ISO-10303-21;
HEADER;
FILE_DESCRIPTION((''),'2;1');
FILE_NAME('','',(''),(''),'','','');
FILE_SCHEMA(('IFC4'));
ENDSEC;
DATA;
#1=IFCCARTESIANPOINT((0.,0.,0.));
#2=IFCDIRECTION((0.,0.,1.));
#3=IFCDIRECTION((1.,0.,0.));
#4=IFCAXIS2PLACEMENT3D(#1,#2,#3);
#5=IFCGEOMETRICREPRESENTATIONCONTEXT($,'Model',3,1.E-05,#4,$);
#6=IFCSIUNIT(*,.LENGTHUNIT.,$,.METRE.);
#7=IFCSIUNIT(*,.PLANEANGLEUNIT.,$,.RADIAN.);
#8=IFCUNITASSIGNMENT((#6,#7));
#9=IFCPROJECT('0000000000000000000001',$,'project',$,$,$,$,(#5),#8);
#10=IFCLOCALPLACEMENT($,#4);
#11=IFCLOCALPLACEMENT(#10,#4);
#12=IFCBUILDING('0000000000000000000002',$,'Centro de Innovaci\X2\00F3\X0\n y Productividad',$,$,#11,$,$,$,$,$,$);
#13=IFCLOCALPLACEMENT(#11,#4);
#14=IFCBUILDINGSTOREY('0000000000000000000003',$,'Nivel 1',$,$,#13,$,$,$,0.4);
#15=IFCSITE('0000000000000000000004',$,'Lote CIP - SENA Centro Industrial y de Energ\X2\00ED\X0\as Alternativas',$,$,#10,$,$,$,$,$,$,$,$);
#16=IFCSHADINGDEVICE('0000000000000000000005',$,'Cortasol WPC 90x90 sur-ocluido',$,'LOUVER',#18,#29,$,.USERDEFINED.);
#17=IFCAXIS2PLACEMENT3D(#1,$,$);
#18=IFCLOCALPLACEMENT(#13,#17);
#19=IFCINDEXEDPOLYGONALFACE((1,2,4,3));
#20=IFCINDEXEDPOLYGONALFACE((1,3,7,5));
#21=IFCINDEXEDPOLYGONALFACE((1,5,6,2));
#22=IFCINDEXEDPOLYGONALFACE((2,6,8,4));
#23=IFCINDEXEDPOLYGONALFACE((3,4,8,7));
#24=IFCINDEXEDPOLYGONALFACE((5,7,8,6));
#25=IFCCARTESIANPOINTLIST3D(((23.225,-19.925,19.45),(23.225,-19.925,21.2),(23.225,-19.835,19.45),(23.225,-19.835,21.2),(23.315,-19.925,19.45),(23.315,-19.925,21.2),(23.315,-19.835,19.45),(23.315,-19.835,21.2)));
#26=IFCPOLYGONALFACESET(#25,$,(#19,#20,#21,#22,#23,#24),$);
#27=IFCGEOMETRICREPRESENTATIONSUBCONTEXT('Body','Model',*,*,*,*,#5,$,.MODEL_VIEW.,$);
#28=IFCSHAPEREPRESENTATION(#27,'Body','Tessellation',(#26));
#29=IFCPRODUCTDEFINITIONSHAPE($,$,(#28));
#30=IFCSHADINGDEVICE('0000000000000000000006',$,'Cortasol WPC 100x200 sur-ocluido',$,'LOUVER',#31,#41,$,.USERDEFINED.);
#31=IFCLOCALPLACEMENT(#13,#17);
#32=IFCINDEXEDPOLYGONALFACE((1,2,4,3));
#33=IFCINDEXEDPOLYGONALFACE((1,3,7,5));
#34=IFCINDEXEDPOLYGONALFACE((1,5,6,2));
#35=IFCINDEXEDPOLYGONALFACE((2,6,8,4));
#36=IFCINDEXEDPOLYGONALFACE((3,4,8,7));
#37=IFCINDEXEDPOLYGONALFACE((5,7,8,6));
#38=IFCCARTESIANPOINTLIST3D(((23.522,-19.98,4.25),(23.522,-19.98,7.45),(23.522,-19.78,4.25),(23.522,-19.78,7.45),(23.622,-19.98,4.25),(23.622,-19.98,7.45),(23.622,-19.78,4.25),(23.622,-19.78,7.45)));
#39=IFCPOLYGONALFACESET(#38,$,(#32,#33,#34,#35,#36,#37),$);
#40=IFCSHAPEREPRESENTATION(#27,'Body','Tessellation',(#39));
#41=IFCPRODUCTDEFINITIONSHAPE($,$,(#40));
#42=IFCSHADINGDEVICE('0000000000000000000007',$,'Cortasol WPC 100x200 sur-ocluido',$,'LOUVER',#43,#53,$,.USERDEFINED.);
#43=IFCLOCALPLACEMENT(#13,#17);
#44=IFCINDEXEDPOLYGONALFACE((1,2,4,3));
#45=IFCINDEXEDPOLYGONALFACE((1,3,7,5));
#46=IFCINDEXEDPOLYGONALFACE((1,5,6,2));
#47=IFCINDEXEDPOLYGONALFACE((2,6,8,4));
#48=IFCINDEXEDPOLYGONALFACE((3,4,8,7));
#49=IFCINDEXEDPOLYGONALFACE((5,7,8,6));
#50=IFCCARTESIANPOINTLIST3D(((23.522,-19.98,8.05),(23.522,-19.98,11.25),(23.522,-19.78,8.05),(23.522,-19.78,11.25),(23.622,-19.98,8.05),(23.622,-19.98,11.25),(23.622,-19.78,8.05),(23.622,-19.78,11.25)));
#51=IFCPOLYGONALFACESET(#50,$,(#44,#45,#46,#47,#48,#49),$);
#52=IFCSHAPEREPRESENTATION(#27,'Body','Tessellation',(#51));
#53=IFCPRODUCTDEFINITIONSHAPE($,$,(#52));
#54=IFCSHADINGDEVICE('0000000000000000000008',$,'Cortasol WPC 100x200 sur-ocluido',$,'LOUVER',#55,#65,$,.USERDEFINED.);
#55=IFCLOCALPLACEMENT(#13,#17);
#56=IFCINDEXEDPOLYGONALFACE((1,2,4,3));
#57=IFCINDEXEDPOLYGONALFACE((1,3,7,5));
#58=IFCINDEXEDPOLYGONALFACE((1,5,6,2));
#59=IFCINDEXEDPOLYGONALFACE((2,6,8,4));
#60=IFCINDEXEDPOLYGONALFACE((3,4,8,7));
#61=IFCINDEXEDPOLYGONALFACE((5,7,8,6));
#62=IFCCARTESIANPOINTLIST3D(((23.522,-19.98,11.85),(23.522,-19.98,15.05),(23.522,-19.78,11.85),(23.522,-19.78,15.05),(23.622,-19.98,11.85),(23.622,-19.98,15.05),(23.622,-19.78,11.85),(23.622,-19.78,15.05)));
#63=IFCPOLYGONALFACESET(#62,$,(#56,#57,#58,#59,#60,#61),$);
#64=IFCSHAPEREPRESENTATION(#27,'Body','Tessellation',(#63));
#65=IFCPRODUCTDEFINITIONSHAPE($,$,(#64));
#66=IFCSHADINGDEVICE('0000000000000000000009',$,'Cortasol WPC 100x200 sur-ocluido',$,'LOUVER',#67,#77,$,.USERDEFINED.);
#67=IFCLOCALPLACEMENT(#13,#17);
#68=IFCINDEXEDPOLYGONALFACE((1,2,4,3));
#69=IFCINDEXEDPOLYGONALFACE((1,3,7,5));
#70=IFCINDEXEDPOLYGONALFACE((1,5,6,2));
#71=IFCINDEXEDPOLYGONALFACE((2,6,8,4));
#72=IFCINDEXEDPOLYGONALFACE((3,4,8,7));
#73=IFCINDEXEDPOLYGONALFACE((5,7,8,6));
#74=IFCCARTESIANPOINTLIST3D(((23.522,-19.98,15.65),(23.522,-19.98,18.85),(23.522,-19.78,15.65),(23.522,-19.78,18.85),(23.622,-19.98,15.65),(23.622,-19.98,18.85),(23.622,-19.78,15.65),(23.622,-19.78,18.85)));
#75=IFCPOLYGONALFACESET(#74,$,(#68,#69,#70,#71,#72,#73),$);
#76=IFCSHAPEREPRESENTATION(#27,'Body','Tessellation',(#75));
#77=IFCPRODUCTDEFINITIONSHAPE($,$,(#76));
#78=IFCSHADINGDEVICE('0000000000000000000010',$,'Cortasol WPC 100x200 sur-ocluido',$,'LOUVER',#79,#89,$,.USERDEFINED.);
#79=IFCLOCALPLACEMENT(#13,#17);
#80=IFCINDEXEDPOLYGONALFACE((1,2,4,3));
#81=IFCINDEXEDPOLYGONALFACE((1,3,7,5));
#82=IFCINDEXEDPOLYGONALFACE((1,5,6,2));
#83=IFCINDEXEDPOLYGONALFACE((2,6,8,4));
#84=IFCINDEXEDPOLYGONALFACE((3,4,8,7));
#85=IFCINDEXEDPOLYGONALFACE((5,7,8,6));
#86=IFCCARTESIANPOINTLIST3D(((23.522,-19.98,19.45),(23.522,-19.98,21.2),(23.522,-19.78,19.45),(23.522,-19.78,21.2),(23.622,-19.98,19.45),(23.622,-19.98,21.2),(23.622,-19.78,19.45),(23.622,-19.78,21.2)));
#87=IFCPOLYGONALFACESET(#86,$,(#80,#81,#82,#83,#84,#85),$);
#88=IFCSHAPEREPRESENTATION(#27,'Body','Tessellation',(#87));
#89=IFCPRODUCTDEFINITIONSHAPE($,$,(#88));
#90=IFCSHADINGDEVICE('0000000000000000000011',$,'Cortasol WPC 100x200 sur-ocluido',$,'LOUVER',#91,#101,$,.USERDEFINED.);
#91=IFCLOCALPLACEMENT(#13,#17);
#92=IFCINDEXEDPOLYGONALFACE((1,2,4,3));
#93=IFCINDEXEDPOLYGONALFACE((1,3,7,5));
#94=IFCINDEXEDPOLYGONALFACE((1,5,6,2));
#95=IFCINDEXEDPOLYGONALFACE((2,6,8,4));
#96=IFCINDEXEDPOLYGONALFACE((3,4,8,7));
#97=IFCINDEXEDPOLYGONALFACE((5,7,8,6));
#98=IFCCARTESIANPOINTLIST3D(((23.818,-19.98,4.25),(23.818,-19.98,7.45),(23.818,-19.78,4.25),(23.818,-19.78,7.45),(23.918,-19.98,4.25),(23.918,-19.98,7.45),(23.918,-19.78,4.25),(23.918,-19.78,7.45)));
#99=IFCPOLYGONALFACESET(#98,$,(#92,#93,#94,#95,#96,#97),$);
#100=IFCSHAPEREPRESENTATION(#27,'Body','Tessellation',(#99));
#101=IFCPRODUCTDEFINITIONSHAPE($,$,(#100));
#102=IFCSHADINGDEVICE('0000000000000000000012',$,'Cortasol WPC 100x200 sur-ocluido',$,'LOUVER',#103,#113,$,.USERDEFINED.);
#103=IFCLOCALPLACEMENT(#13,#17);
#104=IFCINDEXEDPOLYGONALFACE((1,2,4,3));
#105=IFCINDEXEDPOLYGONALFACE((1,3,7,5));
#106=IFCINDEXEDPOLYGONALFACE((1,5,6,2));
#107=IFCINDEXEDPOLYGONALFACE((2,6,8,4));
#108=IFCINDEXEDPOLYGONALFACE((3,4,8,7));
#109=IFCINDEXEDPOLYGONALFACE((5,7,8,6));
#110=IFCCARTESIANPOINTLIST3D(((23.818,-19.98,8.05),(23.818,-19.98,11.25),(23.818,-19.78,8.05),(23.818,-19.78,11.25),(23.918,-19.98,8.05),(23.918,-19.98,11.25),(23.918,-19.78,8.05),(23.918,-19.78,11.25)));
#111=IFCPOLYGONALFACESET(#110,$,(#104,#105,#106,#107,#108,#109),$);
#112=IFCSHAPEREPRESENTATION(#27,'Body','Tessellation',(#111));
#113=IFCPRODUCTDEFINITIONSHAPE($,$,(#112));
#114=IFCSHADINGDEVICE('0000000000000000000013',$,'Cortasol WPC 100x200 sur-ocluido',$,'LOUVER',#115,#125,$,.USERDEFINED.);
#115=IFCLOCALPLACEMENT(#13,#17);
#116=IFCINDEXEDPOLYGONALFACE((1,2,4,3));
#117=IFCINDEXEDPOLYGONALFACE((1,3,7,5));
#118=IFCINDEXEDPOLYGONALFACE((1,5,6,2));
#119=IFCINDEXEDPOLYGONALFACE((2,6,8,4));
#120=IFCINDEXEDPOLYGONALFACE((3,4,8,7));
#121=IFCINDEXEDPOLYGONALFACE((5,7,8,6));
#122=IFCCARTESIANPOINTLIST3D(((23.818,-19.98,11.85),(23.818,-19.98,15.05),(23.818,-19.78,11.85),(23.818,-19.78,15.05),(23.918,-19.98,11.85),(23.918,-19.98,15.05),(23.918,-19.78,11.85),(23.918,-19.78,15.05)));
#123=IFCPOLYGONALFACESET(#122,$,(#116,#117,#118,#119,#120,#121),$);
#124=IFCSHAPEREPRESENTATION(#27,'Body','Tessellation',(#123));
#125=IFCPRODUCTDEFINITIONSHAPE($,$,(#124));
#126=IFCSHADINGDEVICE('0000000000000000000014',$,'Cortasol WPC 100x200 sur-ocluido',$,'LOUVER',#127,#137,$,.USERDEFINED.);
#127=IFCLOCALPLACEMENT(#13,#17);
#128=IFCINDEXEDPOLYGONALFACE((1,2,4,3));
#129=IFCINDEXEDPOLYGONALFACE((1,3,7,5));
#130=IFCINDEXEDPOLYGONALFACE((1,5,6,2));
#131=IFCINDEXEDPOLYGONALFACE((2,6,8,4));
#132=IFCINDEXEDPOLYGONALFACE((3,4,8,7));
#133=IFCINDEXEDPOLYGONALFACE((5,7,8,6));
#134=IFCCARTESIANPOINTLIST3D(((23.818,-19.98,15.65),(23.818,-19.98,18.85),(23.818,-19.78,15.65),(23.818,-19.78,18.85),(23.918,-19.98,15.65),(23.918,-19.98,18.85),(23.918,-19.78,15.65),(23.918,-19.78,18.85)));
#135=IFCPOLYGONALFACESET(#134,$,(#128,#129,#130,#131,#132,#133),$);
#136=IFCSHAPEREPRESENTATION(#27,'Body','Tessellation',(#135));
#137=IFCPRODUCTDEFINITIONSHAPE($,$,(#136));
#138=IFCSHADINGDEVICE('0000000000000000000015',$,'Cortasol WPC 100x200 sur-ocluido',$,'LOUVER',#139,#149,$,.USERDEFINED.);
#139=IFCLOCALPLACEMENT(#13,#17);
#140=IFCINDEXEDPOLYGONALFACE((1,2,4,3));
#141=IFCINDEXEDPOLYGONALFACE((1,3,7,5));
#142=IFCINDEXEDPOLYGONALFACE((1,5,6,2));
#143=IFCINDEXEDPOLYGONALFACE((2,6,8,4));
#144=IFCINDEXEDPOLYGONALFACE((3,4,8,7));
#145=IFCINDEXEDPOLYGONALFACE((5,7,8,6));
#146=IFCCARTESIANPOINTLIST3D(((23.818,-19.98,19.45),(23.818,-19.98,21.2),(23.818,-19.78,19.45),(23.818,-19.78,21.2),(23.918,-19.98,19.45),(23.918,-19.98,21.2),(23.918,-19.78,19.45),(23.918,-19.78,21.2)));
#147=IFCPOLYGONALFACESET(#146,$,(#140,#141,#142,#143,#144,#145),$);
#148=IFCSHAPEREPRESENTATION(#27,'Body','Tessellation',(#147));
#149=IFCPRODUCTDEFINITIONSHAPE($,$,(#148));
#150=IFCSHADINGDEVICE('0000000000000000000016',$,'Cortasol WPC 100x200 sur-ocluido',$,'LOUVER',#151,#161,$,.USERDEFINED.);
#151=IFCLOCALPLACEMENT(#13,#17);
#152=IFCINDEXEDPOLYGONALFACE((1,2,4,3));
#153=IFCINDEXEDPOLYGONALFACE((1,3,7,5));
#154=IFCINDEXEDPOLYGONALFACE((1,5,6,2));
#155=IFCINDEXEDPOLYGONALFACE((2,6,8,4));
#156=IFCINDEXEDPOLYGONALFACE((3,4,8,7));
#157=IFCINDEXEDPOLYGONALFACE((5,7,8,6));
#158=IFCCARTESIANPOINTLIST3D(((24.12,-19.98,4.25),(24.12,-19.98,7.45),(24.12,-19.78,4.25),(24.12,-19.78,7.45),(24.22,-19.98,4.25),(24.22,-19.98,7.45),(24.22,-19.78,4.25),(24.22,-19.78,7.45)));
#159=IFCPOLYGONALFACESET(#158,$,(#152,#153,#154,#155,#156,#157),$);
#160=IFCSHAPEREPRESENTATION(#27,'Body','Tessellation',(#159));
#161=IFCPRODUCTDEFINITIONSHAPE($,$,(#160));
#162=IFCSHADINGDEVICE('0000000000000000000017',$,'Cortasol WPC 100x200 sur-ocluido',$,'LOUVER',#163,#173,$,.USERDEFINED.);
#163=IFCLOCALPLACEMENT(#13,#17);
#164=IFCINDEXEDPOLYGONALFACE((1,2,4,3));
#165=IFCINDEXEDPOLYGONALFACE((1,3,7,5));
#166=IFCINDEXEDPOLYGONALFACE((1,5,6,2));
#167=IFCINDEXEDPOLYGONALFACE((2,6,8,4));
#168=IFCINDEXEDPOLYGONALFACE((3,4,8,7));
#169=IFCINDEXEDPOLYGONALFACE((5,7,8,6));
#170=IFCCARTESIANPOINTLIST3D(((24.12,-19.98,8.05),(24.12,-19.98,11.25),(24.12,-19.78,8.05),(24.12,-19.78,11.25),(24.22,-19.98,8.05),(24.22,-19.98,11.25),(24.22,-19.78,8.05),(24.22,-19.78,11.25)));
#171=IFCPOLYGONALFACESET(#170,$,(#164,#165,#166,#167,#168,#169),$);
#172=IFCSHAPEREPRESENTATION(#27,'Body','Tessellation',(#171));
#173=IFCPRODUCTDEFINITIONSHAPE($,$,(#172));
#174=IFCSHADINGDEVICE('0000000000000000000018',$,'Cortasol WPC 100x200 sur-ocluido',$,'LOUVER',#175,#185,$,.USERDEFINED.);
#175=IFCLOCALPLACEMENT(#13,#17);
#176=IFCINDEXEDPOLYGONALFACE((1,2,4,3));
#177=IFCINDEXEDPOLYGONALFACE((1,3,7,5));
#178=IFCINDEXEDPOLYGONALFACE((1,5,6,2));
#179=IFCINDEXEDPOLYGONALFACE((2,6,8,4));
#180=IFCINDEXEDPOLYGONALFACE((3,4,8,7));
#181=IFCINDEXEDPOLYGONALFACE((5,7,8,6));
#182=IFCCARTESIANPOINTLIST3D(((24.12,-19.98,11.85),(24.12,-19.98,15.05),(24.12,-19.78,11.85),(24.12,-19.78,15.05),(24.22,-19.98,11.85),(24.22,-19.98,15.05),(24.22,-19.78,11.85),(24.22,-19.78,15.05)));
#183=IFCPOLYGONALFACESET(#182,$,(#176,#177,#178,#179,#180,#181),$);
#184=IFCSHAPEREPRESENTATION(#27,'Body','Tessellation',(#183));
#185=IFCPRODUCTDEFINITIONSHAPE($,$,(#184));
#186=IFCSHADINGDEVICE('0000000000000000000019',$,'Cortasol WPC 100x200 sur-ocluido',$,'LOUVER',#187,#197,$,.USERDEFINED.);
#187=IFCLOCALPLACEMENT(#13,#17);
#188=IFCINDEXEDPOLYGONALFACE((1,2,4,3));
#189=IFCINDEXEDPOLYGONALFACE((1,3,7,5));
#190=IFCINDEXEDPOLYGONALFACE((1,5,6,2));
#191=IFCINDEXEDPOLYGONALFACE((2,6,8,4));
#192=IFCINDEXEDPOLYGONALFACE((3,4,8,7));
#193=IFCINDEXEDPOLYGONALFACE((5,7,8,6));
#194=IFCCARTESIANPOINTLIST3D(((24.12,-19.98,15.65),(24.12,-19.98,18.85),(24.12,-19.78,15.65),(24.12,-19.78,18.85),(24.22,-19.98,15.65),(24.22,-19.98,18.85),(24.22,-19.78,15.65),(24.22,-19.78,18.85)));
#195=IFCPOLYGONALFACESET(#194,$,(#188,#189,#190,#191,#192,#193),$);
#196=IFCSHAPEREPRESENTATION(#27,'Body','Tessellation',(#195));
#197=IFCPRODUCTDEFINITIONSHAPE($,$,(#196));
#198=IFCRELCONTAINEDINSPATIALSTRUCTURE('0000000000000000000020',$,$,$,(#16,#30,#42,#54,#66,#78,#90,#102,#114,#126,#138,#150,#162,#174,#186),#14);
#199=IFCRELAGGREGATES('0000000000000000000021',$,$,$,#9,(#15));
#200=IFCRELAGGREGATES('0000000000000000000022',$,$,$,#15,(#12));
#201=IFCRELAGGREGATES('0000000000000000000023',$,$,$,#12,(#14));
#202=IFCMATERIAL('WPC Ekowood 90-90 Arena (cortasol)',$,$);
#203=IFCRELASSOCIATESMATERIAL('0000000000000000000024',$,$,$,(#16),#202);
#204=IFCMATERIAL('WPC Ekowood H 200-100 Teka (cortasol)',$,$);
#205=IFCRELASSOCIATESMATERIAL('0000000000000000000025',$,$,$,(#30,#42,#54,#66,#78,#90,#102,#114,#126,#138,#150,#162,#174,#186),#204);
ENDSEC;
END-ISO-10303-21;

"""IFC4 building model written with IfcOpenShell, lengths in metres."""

from ifc_helpers import new_model, si_unit, frame, origin_with_axes, place, context, subcontext, project, spatial, polyline, outline, extrude, material, element, save


model = new_model("IFC4")

# Units and contexts
model_context = context("Model", 3, precision=1e-05, world=origin_with_axes())
body_context = subcontext(model_context, "Body", "Model", "MODEL_VIEW")
ifc_project = project(units=[si_unit("LENGTHUNIT", "METRE"), si_unit("PLANEANGLEUNIT", "RADIAN")], contexts=[model_context])

# Site, building, storey
site_placement = place(None, origin_with_axes())
site = spatial("IfcSite", under=ifc_project, at=site_placement, Name="Lote CIP - SENA Centro Industrial y de Energías Alternativas")
building_placement = place(site_placement, origin_with_axes())
building = spatial("IfcBuilding", under=site, at=building_placement, Name="Centro de Innovación y Productividad")
storey_placement = place(building_placement, origin_with_axes())
storey = spatial("IfcBuildingStorey", under=building, at=storey_placement, Name="Nivel 1", Elevation=0.4)

# Shading devices
ifc_material_1 = material(Name="WPC Ekowood 90-90 Arena (cortasol)")
shading_device_1_placement = place(storey_placement, origin_with_axes())
element("IfcShadingDevice", 1, at=shading_device_1_placement, inside=storey, material=ifc_material_1, Name="Cortasol WPC 90x90 sur-ocluido", ObjectType="LOUVER", PredefinedType="USERDEFINED", context=body_context, shape_type="SweptSolid", body=[
    extrude(outline(polyline([(23.225, -19.925), (23.225, -19.835), (23.315, -19.835), (23.315, -19.925), (23.225, -19.925)])), frame((0.0, 0.0, 19.45)), (0.0, 0.0, 1.0), 1.75),
])
ifc_material_2 = material(Name="WPC Ekowood H 200-100 Teka (cortasol)")
shading_device_2_placement = place(storey_placement, origin_with_axes())
element("IfcShadingDevice", 2, at=shading_device_2_placement, inside=storey, material=ifc_material_2, Name="Cortasol WPC 100x200 sur-ocluido", ObjectType="LOUVER", PredefinedType="USERDEFINED", context=body_context, shape_type="SweptSolid", body=[
    extrude(outline(polyline([(23.522, -19.98), (23.522, -19.78), (23.622, -19.78), (23.622, -19.98), (23.522, -19.98)])), frame((0.0, 0.0, 4.25)), (0.0, 0.0, 1.0), 3.2),
])
shading_device_3_placement = place(storey_placement, origin_with_axes())
element("IfcShadingDevice", 3, at=shading_device_3_placement, inside=storey, material=ifc_material_2, Name="Cortasol WPC 100x200 sur-ocluido", ObjectType="LOUVER", PredefinedType="USERDEFINED", context=body_context, shape_type="SweptSolid", body=[
    extrude(outline(polyline([(23.522, -19.98), (23.522, -19.78), (23.622, -19.78), (23.622, -19.98), (23.522, -19.98)])), frame((0.0, 0.0, 8.05)), (0.0, 0.0, 1.0), 3.2),
])
shading_device_4_placement = place(storey_placement, origin_with_axes())
element("IfcShadingDevice", 4, at=shading_device_4_placement, inside=storey, material=ifc_material_2, Name="Cortasol WPC 100x200 sur-ocluido", ObjectType="LOUVER", PredefinedType="USERDEFINED", context=body_context, shape_type="SweptSolid", body=[
    extrude(outline(polyline([(23.522, -19.98), (23.522, -19.78), (23.622, -19.78), (23.622, -19.98), (23.522, -19.98)])), frame((0.0, 0.0, 11.85)), (0.0, 0.0, 1.0), 3.2),
])
shading_device_5_placement = place(storey_placement, origin_with_axes())
element("IfcShadingDevice", 5, at=shading_device_5_placement, inside=storey, material=ifc_material_2, Name="Cortasol WPC 100x200 sur-ocluido", ObjectType="LOUVER", PredefinedType="USERDEFINED", context=body_context, shape_type="SweptSolid", body=[
    extrude(outline(polyline([(23.522, -19.98), (23.522, -19.78), (23.622, -19.78), (23.622, -19.98), (23.522, -19.98)])), frame((0.0, 0.0, 15.65)), (0.0, 0.0, 1.0), 3.2),
])
shading_device_6_placement = place(storey_placement, origin_with_axes())
element("IfcShadingDevice", 6, at=shading_device_6_placement, inside=storey, material=ifc_material_2, Name="Cortasol WPC 100x200 sur-ocluido", ObjectType="LOUVER", PredefinedType="USERDEFINED", context=body_context, shape_type="SweptSolid", body=[
    extrude(outline(polyline([(23.522, -19.98), (23.522, -19.78), (23.622, -19.78), (23.622, -19.98), (23.522, -19.98)])), frame((0.0, 0.0, 19.45)), (0.0, 0.0, 1.0), 1.75),
])
shading_device_7_placement = place(storey_placement, origin_with_axes())
element("IfcShadingDevice", 7, at=shading_device_7_placement, inside=storey, material=ifc_material_2, Name="Cortasol WPC 100x200 sur-ocluido", ObjectType="LOUVER", PredefinedType="USERDEFINED", context=body_context, shape_type="SweptSolid", body=[
    extrude(outline(polyline([(23.818, -19.98), (23.818, -19.78), (23.918, -19.78), (23.918, -19.98), (23.818, -19.98)])), frame((0.0, 0.0, 4.25)), (0.0, 0.0, 1.0), 3.2),
])
shading_device_8_placement = place(storey_placement, origin_with_axes())
element("IfcShadingDevice", 8, at=shading_device_8_placement, inside=storey, material=ifc_material_2, Name="Cortasol WPC 100x200 sur-ocluido", ObjectType="LOUVER", PredefinedType="USERDEFINED", context=body_context, shape_type="SweptSolid", body=[
    extrude(outline(polyline([(23.818, -19.98), (23.818, -19.78), (23.918, -19.78), (23.918, -19.98), (23.818, -19.98)])), frame((0.0, 0.0, 8.05)), (0.0, 0.0, 1.0), 3.2),
])
shading_device_9_placement = place(storey_placement, origin_with_axes())
element("IfcShadingDevice", 9, at=shading_device_9_placement, inside=storey, material=ifc_material_2, Name="Cortasol WPC 100x200 sur-ocluido", ObjectType="LOUVER", PredefinedType="USERDEFINED", context=body_context, shape_type="SweptSolid", body=[
    extrude(outline(polyline([(23.818, -19.98), (23.818, -19.78), (23.918, -19.78), (23.918, -19.98), (23.818, -19.98)])), frame((0.0, 0.0, 11.85)), (0.0, 0.0, 1.0), 3.2),
])
shading_device_10_placement = place(storey_placement, origin_with_axes())
element("IfcShadingDevice", 10, at=shading_device_10_placement, inside=storey, material=ifc_material_2, Name="Cortasol WPC 100x200 sur-ocluido", ObjectType="LOUVER", PredefinedType="USERDEFINED", context=body_context, shape_type="SweptSolid", body=[
    extrude(outline(polyline([(23.818, -19.98), (23.818, -19.78), (23.918, -19.78), (23.918, -19.98), (23.818, -19.98)])), frame((0.0, 0.0, 15.65)), (0.0, 0.0, 1.0), 3.2),
])
shading_device_11_placement = place(storey_placement, origin_with_axes())
element("IfcShadingDevice", 11, at=shading_device_11_placement, inside=storey, material=ifc_material_2, Name="Cortasol WPC 100x200 sur-ocluido", ObjectType="LOUVER", PredefinedType="USERDEFINED", context=body_context, shape_type="SweptSolid", body=[
    extrude(outline(polyline([(23.818, -19.98), (23.818, -19.78), (23.918, -19.78), (23.918, -19.98), (23.818, -19.98)])), frame((0.0, 0.0, 19.45)), (0.0, 0.0, 1.0), 1.75),
])
shading_device_12_placement = place(storey_placement, origin_with_axes())
element("IfcShadingDevice", 12, at=shading_device_12_placement, inside=storey, material=ifc_material_2, Name="Cortasol WPC 100x200 sur-ocluido", ObjectType="LOUVER", PredefinedType="USERDEFINED", context=body_context, shape_type="SweptSolid", body=[
    extrude(outline(polyline([(24.12, -19.98), (24.12, -19.78), (24.22, -19.78), (24.22, -19.98), (24.12, -19.98)])), frame((0.0, 0.0, 4.25)), (0.0, 0.0, 1.0), 3.2),
])
shading_device_13_placement = place(storey_placement, origin_with_axes())
element("IfcShadingDevice", 13, at=shading_device_13_placement, inside=storey, material=ifc_material_2, Name="Cortasol WPC 100x200 sur-ocluido", ObjectType="LOUVER", PredefinedType="USERDEFINED", context=body_context, shape_type="SweptSolid", body=[
    extrude(outline(polyline([(24.12, -19.98), (24.12, -19.78), (24.22, -19.78), (24.22, -19.98), (24.12, -19.98)])), frame((0.0, 0.0, 8.05)), (0.0, 0.0, 1.0), 3.2),
])
shading_device_14_placement = place(storey_placement, origin_with_axes())
element("IfcShadingDevice", 14, at=shading_device_14_placement, inside=storey, material=ifc_material_2, Name="Cortasol WPC 100x200 sur-ocluido", ObjectType="LOUVER", PredefinedType="USERDEFINED", context=body_context, shape_type="SweptSolid", body=[
    extrude(outline(polyline([(24.12, -19.98), (24.12, -19.78), (24.22, -19.78), (24.22, -19.98), (24.12, -19.98)])), frame((0.0, 0.0, 11.85)), (0.0, 0.0, 1.0), 3.2),
])
shading_device_15_placement = place(storey_placement, origin_with_axes())
element("IfcShadingDevice", 15, at=shading_device_15_placement, inside=storey, material=ifc_material_2, Name="Cortasol WPC 100x200 sur-ocluido", ObjectType="LOUVER", PredefinedType="USERDEFINED", context=body_context, shape_type="SweptSolid", body=[
    extrude(outline(polyline([(24.12, -19.98), (24.12, -19.78), (24.22, -19.78), (24.22, -19.98), (24.12, -19.98)])), frame((0.0, 0.0, 15.65)), (0.0, 0.0, 1.0), 3.2),
])

save(model, "model.ifc")
